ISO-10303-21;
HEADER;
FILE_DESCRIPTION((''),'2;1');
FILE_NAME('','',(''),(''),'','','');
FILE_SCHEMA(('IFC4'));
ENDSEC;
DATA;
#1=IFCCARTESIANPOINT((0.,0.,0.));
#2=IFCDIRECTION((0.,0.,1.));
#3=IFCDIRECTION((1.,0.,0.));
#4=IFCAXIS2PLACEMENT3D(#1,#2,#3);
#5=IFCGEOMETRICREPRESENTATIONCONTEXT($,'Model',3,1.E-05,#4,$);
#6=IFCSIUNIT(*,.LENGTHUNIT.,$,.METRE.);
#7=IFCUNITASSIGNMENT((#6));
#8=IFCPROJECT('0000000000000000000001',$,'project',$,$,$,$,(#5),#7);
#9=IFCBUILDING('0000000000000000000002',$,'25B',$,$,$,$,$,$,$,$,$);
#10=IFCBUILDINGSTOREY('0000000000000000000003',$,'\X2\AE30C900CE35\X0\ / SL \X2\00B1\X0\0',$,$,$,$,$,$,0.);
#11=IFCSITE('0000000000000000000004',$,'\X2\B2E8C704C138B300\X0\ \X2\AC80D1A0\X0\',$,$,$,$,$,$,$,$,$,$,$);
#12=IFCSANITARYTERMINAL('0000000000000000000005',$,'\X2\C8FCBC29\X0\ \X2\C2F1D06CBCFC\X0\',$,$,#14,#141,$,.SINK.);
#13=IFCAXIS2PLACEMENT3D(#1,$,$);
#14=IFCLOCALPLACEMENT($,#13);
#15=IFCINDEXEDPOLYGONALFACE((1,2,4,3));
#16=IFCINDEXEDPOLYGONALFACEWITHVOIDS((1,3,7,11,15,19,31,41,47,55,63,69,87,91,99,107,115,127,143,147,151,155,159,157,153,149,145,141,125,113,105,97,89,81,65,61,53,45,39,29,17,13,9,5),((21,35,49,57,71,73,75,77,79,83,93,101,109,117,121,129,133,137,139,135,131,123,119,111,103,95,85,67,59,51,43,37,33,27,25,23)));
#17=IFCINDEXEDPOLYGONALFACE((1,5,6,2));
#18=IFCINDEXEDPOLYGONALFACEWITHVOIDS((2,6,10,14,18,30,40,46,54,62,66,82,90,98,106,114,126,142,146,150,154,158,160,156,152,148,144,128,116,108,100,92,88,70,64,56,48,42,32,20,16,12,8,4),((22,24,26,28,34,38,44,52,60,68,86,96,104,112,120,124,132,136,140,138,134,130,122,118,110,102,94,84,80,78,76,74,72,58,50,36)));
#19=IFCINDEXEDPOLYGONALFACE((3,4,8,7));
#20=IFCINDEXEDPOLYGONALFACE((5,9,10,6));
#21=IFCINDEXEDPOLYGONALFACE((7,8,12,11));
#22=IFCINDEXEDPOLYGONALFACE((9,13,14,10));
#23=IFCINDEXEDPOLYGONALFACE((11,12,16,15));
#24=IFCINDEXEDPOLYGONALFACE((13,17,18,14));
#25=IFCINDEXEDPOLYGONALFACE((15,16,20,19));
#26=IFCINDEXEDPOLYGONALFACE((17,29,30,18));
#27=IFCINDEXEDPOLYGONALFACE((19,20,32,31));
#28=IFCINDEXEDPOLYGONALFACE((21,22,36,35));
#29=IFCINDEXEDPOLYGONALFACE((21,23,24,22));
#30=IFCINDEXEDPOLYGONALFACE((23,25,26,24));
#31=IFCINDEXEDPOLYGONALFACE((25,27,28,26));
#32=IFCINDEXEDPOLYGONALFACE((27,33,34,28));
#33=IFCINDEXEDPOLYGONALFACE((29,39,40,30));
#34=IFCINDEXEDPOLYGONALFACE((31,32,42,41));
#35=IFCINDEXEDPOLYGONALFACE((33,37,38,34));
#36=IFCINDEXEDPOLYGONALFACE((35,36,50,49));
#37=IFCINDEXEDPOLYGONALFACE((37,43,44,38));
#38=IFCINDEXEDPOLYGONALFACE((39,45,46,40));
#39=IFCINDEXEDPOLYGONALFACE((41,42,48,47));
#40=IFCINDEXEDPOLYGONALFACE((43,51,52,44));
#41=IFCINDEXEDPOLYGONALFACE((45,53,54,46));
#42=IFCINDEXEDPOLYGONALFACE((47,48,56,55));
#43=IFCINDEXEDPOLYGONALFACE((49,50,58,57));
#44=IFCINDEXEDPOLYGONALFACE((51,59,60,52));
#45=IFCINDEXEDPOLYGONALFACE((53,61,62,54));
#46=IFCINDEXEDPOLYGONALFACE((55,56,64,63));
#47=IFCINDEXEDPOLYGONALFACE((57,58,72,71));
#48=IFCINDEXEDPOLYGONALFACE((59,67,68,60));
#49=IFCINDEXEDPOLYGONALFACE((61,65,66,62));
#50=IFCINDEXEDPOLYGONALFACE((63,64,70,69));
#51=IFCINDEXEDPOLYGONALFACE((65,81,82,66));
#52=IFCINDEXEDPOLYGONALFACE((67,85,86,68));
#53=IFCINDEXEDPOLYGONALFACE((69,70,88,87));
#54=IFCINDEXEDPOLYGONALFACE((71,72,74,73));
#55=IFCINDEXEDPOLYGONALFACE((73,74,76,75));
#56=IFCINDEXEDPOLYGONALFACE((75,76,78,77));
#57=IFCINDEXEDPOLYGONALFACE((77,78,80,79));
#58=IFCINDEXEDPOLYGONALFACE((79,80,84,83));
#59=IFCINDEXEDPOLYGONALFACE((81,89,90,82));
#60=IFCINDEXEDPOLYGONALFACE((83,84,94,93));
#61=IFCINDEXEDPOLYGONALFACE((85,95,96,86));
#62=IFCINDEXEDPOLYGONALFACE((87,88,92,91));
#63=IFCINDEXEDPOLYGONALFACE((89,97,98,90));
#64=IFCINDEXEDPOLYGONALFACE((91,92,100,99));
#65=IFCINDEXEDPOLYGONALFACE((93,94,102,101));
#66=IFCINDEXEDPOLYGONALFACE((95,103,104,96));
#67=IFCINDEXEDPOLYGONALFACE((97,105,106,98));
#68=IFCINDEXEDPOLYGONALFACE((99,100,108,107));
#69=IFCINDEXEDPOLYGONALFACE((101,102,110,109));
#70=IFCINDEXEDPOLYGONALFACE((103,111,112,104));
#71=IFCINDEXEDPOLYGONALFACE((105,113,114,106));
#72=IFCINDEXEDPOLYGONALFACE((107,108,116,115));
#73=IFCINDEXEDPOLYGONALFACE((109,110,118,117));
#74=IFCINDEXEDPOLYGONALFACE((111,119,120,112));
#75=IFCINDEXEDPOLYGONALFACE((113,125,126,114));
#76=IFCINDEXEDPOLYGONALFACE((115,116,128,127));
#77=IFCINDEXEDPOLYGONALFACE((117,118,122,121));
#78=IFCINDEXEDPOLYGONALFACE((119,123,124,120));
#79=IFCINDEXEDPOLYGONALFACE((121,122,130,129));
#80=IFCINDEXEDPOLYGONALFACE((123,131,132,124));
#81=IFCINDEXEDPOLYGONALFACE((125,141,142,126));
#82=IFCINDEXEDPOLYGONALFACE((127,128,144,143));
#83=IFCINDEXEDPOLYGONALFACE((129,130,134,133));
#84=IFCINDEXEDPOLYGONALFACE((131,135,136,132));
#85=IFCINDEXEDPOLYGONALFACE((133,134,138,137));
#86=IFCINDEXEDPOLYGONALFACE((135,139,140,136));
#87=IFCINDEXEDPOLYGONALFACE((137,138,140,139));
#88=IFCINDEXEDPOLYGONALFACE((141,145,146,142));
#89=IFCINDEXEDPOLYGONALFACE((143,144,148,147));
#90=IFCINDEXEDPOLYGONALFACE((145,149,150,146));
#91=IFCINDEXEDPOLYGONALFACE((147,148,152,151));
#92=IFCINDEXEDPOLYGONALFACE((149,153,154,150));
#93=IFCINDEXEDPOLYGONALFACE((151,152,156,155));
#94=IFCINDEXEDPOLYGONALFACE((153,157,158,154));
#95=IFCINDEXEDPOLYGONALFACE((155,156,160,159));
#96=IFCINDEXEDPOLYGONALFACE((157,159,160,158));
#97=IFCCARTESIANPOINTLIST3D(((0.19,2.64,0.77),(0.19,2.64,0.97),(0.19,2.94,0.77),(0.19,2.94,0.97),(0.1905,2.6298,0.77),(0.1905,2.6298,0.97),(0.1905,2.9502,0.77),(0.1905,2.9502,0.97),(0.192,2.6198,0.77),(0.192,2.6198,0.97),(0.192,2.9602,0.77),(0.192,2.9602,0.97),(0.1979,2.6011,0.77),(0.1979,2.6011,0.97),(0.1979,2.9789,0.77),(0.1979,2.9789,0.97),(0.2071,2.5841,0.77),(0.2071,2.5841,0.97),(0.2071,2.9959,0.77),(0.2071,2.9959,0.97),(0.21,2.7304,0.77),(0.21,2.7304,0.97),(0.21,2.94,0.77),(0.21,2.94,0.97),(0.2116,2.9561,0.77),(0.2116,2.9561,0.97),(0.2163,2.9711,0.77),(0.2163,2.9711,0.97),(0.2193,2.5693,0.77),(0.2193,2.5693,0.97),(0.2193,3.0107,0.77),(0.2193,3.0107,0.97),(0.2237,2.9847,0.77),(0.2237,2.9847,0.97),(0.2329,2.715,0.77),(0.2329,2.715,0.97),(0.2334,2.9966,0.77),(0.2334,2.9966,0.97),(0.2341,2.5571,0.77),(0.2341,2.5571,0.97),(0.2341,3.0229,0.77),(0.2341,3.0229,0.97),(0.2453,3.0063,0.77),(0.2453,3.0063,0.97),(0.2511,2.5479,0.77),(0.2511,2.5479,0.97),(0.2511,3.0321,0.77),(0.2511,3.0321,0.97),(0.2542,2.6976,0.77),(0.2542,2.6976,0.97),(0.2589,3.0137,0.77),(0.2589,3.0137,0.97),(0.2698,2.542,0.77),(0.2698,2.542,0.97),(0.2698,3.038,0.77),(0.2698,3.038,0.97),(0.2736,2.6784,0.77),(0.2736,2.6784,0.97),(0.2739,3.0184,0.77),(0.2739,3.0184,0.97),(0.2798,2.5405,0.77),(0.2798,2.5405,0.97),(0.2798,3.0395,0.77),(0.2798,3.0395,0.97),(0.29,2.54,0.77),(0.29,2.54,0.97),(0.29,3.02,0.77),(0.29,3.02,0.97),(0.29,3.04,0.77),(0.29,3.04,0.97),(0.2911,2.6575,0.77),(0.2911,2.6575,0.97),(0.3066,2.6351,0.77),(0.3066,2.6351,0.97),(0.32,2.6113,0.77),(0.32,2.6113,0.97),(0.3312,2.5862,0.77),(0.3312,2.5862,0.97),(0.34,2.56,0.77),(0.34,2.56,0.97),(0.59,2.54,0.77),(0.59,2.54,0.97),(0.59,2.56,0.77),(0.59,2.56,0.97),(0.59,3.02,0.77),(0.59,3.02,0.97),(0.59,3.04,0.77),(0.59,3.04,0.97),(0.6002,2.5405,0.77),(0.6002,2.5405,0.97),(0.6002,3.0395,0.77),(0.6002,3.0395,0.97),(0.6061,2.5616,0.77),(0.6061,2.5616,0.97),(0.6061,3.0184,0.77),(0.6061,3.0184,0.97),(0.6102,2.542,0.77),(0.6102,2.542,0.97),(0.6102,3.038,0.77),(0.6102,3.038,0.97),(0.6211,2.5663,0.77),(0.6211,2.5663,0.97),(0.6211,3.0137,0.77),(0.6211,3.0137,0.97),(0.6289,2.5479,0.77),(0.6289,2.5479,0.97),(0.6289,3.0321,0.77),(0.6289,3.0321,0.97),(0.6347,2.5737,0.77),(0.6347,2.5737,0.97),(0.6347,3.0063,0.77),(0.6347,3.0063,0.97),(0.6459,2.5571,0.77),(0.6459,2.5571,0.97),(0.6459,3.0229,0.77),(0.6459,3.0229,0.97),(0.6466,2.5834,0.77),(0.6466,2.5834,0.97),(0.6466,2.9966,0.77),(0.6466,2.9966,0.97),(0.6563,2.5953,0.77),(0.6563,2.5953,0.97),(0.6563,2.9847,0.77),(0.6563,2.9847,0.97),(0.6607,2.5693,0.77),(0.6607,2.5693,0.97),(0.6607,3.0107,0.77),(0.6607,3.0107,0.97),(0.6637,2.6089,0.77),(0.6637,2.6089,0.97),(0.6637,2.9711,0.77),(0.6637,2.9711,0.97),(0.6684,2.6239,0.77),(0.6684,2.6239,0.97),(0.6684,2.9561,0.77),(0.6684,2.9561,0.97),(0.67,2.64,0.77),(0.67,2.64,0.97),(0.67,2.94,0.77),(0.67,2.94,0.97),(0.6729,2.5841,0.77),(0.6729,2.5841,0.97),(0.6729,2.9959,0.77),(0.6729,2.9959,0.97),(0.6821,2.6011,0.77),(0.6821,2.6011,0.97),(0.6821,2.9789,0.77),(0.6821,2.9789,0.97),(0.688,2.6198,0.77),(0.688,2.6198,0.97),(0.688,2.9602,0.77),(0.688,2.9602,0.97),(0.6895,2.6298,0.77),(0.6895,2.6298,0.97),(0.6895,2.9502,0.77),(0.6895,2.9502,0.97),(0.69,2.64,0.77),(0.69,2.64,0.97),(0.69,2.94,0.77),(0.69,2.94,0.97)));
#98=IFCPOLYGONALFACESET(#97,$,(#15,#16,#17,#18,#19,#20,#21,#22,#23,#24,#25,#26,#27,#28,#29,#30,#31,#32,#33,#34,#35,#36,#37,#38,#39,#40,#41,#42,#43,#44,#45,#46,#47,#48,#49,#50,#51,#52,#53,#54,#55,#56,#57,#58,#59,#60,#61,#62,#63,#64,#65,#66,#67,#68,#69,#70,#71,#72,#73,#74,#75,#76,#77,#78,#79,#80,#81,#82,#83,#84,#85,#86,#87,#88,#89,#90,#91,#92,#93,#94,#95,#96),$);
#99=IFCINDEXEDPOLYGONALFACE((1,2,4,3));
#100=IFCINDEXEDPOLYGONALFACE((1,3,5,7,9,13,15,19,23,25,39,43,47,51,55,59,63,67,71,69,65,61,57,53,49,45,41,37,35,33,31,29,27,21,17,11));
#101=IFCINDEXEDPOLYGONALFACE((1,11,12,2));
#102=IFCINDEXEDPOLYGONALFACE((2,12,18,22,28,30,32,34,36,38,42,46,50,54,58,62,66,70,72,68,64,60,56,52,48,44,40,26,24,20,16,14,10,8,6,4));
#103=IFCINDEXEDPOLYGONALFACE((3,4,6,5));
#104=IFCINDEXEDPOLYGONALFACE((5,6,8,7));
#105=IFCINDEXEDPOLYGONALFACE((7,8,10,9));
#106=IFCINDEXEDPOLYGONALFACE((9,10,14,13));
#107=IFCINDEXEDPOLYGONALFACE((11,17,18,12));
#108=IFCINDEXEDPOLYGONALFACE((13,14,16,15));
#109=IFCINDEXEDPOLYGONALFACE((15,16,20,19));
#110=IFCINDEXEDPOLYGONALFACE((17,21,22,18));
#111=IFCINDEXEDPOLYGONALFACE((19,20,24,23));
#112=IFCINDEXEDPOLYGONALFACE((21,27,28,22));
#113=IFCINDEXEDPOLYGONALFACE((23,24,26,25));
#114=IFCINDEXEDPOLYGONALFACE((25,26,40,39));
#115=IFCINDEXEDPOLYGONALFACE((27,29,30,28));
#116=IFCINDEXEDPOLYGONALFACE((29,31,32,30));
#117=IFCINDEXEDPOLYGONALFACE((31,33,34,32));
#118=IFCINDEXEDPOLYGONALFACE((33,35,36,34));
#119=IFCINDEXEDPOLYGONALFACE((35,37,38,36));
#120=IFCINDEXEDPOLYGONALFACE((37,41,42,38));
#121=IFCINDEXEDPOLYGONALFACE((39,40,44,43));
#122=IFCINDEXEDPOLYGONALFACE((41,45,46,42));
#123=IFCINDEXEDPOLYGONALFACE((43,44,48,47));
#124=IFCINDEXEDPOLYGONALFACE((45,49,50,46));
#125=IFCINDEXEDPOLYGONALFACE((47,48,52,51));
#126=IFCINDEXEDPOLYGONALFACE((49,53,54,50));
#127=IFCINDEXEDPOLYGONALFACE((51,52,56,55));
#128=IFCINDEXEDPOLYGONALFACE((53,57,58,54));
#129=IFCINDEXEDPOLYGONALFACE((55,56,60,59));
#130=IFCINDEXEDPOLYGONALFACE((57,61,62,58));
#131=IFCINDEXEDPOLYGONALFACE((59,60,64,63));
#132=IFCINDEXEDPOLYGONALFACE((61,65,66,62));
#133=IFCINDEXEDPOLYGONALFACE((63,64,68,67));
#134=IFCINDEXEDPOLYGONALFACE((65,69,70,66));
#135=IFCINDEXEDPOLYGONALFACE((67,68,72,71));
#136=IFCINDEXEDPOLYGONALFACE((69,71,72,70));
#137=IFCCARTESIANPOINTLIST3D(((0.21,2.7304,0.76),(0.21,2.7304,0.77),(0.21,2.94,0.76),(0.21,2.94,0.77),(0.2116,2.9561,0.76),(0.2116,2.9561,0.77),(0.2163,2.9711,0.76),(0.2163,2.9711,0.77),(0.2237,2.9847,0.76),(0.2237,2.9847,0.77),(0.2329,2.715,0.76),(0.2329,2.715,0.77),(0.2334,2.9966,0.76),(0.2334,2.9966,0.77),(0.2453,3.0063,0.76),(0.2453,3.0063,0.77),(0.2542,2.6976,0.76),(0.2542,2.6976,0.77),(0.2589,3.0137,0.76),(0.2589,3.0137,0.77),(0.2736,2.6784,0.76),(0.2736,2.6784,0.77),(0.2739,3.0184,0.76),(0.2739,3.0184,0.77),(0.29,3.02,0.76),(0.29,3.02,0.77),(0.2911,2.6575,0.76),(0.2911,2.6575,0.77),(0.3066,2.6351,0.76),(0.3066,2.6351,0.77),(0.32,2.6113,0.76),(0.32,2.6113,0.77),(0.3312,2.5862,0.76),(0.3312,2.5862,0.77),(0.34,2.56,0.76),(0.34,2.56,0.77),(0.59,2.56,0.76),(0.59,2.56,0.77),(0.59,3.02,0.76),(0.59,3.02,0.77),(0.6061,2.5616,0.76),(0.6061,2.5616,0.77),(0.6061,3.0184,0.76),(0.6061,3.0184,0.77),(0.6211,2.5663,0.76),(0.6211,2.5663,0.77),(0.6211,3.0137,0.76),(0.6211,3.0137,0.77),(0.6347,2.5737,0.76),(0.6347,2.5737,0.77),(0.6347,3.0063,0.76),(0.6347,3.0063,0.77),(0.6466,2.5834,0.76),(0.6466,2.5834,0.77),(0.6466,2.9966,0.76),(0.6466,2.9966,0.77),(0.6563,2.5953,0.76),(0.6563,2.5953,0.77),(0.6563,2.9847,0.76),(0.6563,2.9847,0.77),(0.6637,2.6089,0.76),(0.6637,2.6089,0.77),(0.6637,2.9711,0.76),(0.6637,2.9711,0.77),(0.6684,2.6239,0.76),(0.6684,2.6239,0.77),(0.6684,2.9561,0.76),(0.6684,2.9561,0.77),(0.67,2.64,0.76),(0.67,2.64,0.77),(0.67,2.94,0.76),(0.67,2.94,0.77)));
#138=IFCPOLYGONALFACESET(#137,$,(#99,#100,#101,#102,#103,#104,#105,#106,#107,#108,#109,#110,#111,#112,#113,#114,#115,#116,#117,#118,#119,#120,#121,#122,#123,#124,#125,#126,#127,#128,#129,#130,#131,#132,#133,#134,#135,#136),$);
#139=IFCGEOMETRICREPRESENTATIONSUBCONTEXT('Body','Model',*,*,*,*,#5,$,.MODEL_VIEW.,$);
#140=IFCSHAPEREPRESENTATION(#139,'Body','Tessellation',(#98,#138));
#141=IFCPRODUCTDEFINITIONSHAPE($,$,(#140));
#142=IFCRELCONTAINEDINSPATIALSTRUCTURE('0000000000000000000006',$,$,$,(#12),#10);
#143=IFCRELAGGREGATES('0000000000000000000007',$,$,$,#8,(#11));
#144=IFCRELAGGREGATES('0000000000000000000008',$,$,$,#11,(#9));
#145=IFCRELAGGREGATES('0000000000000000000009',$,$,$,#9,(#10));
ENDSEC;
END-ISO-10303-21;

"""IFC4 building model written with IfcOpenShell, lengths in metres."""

from ifc_helpers import new_model, si_unit, frame, origin_with_axes, place, context, subcontext, project, spatial, polyline, outline, extrude, element, save


model = new_model("IFC4")

# Units and contexts
model_context = context("Model", 3, precision=1e-05, world=origin_with_axes())
body_context = subcontext(model_context, "Body", "Model", "MODEL_VIEW")
ifc_project = project(units=[si_unit("LENGTHUNIT", "METRE")], contexts=[model_context])

# Site, building, storey
site = spatial("IfcSite", under=ifc_project, Name="단위세대 검토")
building = spatial("IfcBuilding", under=site, Name="25B")
storey = spatial("IfcBuildingStorey", under=building, Name="기준층 / SL ±0", Elevation=0.0)

# Sanitary terminal
sanitary_terminal_placement = place(None, origin_with_axes())
element("IfcSanitaryTerminal", 1, at=sanitary_terminal_placement, inside=storey, Name="주방 싱크볼", PredefinedType="SINK", context=body_context, shape_type="SweptSolid", body=[
    extrude(outline(polyline([(0.69, 2.64), (0.6895, 2.6298), (0.688, 2.6198), (0.6821, 2.6011), (0.6729, 2.5841), (0.6607, 2.5693), (0.6459, 2.5571), (0.6289, 2.5479), (0.6102, 2.542), (0.6002, 2.5405), (0.59, 2.54), (0.29, 2.54), (0.2798, 2.5405), (0.2698, 2.542), (0.2511, 2.5479), (0.2341, 2.5571), (0.2193, 2.5693), (0.2071, 2.5841), (0.1979, 2.6011), (0.192, 2.6198), (0.1905, 2.6298), (0.19, 2.64), (0.19, 2.94), (0.1905, 2.9502), (0.192, 2.9602), (0.1979, 2.9789), (0.2071, 2.9959), (0.2193, 3.0107), (0.2341, 3.0229), (0.2511, 3.0321), (0.2698, 3.038), (0.2798, 3.0395), (0.29, 3.04), (0.59, 3.04), (0.6002, 3.0395), (0.6102, 3.038), (0.6289, 3.0321), (0.6459, 3.0229), (0.6607, 3.0107), (0.6729, 2.9959), (0.6821, 2.9789), (0.688, 2.9602), (0.6895, 2.9502), (0.69, 2.94), (0.69, 2.64)]), holes=[polyline([(0.6684, 2.9561), (0.6637, 2.9711), (0.6563, 2.9847), (0.6466, 2.9966), (0.6347, 3.0063), (0.6211, 3.0137), (0.6061, 3.0184), (0.59, 3.02), (0.29, 3.02), (0.2739, 3.0184), (0.2589, 3.0137), (0.2453, 3.0063), (0.2334, 2.9966), (0.2237, 2.9847), (0.2163, 2.9711), (0.2116, 2.9561), (0.21, 2.94), (0.21, 2.7304), (0.2329, 2.715), (0.2542, 2.6976), (0.2736, 2.6784), (0.2911, 2.6575), (0.3066, 2.6351), (0.32, 2.6113), (0.3312, 2.5862), (0.34, 2.56), (0.59, 2.56), (0.6061, 2.5616), (0.6211, 2.5663), (0.6347, 2.5737), (0.6466, 2.5834), (0.6563, 2.5953), (0.6637, 2.6089), (0.6684, 2.6239), (0.67, 2.64), (0.67, 2.94), (0.6684, 2.9561)])]), frame((0.0, 0.0, 0.77)), (0.0, 0.0, 1.0), 0.2),
    extrude(outline(polyline([(0.67, 2.94), (0.67, 2.64), (0.6684, 2.6239), (0.6637, 2.6089), (0.6563, 2.5953), (0.6466, 2.5834), (0.6347, 2.5737), (0.6211, 2.5663), (0.6061, 2.5616), (0.59, 2.56), (0.34, 2.56), (0.3312, 2.5862), (0.32, 2.6113), (0.3066, 2.6351), (0.2911, 2.6575), (0.2736, 2.6784), (0.2542, 2.6976), (0.2329, 2.715), (0.21, 2.7304), (0.21, 2.94), (0.2116, 2.9561), (0.2163, 2.9711), (0.2237, 2.9847), (0.2334, 2.9966), (0.2453, 3.0063), (0.2589, 3.0137), (0.2739, 3.0184), (0.29, 3.02), (0.59, 3.02), (0.6061, 3.0184), (0.6211, 3.0137), (0.6347, 3.0063), (0.6466, 2.9966), (0.6563, 2.9847), (0.6637, 2.9711), (0.6684, 2.9561), (0.67, 2.94)])), frame((0.0, 0.0, 0.76)), (0.0, 0.0, 1.0), 0.01),
])

save(model, "model.ifc")
